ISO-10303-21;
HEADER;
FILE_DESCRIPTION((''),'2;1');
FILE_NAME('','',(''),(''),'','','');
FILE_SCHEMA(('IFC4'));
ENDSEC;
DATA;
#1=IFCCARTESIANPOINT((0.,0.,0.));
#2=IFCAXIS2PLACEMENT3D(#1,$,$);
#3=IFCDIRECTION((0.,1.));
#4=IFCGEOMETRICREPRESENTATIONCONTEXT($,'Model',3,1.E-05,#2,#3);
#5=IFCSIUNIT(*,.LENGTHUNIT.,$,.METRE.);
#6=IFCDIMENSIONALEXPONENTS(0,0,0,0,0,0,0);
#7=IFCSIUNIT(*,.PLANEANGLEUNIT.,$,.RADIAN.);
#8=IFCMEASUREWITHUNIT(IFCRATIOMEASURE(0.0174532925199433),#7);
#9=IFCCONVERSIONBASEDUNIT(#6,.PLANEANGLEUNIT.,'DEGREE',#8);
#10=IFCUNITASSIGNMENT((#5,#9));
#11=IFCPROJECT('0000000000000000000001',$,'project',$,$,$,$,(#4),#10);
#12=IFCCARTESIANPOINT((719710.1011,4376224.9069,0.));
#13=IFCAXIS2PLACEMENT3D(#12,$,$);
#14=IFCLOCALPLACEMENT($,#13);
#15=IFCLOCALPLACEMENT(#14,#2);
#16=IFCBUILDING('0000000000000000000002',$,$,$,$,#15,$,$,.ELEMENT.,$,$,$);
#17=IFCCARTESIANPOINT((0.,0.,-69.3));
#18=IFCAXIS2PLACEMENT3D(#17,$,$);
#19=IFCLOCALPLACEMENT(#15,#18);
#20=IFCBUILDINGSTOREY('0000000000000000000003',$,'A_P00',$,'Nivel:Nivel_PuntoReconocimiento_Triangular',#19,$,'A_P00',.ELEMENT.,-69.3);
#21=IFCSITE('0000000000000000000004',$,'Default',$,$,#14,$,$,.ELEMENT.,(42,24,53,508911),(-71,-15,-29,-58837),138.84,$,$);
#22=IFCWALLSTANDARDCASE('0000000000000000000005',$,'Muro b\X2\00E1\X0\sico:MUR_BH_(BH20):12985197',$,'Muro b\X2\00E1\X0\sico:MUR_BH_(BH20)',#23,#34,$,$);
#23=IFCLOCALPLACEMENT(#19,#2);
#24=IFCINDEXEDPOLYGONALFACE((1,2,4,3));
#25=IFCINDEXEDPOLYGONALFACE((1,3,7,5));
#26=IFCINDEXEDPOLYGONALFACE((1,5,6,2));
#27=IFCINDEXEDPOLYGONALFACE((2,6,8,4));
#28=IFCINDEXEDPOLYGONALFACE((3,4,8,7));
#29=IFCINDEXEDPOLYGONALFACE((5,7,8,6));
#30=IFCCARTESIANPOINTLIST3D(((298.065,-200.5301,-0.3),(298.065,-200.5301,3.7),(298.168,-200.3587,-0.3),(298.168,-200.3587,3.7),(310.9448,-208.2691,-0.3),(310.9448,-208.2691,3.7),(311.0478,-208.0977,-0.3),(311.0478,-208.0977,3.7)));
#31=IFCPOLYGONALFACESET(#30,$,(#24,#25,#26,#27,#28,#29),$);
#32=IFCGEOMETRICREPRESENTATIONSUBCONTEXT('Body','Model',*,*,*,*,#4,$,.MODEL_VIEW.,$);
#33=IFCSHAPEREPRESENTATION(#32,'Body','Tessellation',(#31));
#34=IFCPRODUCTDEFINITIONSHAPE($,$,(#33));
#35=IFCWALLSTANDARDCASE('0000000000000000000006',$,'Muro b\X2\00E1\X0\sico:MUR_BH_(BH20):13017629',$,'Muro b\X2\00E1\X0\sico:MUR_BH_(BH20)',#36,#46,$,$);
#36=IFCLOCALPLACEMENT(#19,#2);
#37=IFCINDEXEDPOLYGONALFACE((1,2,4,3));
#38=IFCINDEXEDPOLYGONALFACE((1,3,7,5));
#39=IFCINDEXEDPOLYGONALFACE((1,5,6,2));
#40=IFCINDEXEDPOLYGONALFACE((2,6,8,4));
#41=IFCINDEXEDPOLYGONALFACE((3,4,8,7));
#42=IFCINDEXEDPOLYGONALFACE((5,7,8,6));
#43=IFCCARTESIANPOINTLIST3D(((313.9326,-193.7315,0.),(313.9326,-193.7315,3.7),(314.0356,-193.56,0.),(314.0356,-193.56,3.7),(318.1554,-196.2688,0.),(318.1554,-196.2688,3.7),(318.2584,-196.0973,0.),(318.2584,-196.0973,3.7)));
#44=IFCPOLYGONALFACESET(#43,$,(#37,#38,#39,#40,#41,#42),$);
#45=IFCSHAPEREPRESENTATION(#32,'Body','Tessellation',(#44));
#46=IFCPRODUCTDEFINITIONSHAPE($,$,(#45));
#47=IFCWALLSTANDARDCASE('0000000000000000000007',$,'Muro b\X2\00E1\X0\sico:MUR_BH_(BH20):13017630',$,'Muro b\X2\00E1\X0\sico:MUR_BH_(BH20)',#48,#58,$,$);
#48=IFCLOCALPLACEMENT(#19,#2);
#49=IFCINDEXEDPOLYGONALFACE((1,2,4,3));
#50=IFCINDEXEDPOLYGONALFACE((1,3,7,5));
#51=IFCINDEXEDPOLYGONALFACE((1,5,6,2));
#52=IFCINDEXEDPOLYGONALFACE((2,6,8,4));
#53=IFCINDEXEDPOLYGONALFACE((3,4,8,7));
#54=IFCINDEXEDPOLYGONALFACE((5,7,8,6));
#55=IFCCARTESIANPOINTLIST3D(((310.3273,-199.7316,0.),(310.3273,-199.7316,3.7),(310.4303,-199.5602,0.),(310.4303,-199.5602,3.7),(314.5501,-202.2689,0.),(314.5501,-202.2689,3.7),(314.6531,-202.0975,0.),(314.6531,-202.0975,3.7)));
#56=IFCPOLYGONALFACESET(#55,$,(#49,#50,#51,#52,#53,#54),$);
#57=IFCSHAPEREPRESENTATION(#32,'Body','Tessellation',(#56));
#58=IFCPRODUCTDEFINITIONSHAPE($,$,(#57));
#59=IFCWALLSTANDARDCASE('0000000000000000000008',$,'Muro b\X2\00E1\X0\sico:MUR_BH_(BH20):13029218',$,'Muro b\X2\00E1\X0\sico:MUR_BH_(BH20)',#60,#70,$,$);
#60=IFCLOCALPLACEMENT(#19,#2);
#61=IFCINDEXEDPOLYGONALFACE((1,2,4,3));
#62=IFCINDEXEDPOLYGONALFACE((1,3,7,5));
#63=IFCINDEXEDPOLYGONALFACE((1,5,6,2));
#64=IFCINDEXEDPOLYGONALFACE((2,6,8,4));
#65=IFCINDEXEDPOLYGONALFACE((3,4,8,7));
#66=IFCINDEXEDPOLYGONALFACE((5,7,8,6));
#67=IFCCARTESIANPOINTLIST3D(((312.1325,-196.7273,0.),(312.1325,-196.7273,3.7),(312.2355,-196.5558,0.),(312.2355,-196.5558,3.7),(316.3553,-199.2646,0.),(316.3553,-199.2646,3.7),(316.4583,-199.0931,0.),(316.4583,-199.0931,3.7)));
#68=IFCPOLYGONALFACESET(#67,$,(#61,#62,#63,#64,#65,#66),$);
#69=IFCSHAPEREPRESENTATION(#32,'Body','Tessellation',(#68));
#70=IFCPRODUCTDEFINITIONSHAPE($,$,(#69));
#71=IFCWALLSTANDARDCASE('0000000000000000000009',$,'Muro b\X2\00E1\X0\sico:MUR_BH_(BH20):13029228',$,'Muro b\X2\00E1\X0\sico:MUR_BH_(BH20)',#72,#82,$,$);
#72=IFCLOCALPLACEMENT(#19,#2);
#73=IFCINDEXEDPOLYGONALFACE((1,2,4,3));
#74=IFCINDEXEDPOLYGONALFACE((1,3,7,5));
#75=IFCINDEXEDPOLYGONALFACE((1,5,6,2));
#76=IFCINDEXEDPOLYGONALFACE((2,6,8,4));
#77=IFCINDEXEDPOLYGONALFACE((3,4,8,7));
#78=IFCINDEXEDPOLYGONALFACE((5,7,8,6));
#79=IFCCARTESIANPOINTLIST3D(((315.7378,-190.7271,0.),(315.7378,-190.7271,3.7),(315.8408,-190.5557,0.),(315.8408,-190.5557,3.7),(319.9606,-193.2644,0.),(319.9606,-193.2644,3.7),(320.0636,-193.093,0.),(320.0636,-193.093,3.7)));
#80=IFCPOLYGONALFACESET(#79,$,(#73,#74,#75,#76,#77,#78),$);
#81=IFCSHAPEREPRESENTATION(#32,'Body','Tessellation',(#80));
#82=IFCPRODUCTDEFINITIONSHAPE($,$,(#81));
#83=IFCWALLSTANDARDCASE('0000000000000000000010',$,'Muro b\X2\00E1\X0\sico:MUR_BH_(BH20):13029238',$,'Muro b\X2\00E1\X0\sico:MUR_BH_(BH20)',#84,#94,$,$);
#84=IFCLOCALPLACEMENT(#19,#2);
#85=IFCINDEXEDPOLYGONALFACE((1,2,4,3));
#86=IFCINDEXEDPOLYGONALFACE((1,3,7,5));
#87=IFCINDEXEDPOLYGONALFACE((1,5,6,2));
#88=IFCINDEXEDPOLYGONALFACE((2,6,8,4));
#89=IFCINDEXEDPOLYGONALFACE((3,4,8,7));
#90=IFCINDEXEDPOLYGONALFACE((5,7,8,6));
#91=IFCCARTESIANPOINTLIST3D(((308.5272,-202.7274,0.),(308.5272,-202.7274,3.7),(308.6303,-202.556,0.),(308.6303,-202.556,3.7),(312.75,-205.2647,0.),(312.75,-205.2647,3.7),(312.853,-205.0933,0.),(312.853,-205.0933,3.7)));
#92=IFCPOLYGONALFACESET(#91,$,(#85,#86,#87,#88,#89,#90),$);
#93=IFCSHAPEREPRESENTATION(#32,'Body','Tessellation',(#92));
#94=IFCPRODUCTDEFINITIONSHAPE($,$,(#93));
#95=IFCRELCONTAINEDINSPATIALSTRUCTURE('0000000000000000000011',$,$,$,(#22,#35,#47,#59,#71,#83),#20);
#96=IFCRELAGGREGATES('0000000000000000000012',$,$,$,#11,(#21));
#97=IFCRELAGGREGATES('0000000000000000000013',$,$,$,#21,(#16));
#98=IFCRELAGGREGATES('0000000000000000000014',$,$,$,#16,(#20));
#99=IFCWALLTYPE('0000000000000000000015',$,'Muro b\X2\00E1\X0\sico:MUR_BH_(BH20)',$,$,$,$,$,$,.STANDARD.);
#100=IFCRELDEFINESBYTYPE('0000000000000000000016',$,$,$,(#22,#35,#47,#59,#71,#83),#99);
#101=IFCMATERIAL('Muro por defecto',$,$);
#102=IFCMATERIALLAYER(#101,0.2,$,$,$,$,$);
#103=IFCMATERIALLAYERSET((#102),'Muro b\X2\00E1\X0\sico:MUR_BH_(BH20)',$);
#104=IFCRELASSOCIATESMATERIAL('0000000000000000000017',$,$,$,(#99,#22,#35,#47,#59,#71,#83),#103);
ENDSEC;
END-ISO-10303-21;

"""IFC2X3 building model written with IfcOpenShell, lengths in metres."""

from ifc_helpers import new_model, entity, si_unit, converted_unit, direction, frame, frame_2d, origin, place, context, subcontext, project, spatial, rectangle, extrude, material, layer, layer_set, layer_usage, type_object, element, save


model = new_model("IFC2X3")

# Units and contexts
model_context = context("Model", 3, precision=1e-05, world=origin(), true_north=direction((0.0, 1.0)))
body_context = subcontext(model_context, "Body", "Model", "MODEL_VIEW")
ifc_project = project(units=[si_unit("LENGTHUNIT", "METRE"), converted_unit("PLANEANGLEUNIT", "DEGREE", entity("IfcRatioMeasure", 0.0174532925199433), si_unit("PLANEANGLEUNIT", "RADIAN"), dimensions=[0, 0, 0, 0, 0, 0, 0])], contexts=[model_context])

# Site, building, storey
site_placement = place(None, frame((719710.1011, 4376224.9069, 0.0)))
site = spatial("IfcSite", under=ifc_project, at=site_placement, Name="Default", CompositionType="ELEMENT", RefLatitude=(42, 24, 53, 508911), RefLongitude=(-71, -15, -29, -58837), RefElevation=138.84)
building_placement = place(site_placement, origin())
building = spatial("IfcBuilding", under=site, at=building_placement, CompositionType="ELEMENT")
storey_placement = place(building_placement, frame((0.0, 0.0, -69.3)))
storey = spatial("IfcBuildingStorey", under=building, at=storey_placement, Name="A_P00", ObjectType="Nivel:Nivel_PuntoReconocimiento_Triangular", LongName="A_P00", CompositionType="ELEMENT", Elevation=-69.3)

# Walls
ifc_material_1 = material(Name="Muro por defecto")
ifc_layer = layer(ifc_material_1, 0.2)
ifc_layer_set = layer_set([ifc_layer], Name="Muro básico:MUR_BH_(BH20)")
ifc_layer_usage_1 = layer_usage(ifc_layer_set, "AXIS2", "NEGATIVE", 0.1)
wall_type = type_object("IfcWallType", Name="Muro básico:MUR_BH_(BH20)", PredefinedType="STANDARD", material=ifc_layer_set)
wall_1_placement = place(storey_placement, frame((310.9963, -208.1834, -0.3), z_axis=(0.0, 0.0, 1.0), x_axis=(-0.857167, 0.515038, 0.0)))
element("IfcWallStandardCase", 1, at=wall_1_placement, inside=storey, type_object=wall_type, material=ifc_layer_usage_1, Name="Muro básico:MUR_BH_(BH20):12985197", ObjectType="Muro básico:MUR_BH_(BH20)", context=body_context, shape_type="SweptSolid", body=[
    extrude(rectangle(XDim=15.026, YDim=0.2, at=frame_2d((7.513, 0.0), x_axis=(-1.0, 0.0))), origin(), (0.0, 0.0, 1.0), 4.0),
])
ifc_layer_usage_2 = layer_usage(ifc_layer_set, "AXIS2", "NEGATIVE", 0.1)
wall_2_placement = place(storey_placement, frame((313.9841, -193.6457, 0.0), z_axis=(0.0, 0.0, 1.0), x_axis=(0.857167, -0.515038, 0.0)))
element("IfcWallStandardCase", 2, at=wall_2_placement, inside=storey, type_object=wall_type, material=ifc_layer_usage_2, Name="Muro básico:MUR_BH_(BH20):13017629", ObjectType="Muro básico:MUR_BH_(BH20)", context=body_context, shape_type="SweptSolid", body=[
    extrude(rectangle(XDim=4.9264, YDim=0.2, at=frame_2d((2.4632, 0.0), x_axis=(-1.0, 0.0))), origin(), (0.0, 0.0, 1.0), 3.7),
])
ifc_layer_usage_3 = layer_usage(ifc_layer_set, "AXIS2", "NEGATIVE", 0.1)
wall_3_placement = place(storey_placement, frame((310.3788, -199.6459, 0.0), z_axis=(0.0, 0.0, 1.0), x_axis=(0.857167, -0.515038, 0.0)))
element("IfcWallStandardCase", 3, at=wall_3_placement, inside=storey, type_object=wall_type, material=ifc_layer_usage_3, Name="Muro básico:MUR_BH_(BH20):13017630", ObjectType="Muro básico:MUR_BH_(BH20)", context=body_context, shape_type="SweptSolid", body=[
    extrude(rectangle(XDim=4.9264, YDim=0.2, at=frame_2d((2.4632, 0.0), x_axis=(-1.0, 0.0))), origin(), (0.0, 0.0, 1.0), 3.7),
])
ifc_layer_usage_4 = layer_usage(ifc_layer_set, "AXIS2", "NEGATIVE", 0.1)
wall_4_placement = place(storey_placement, frame((312.184, -196.6415, 0.0), z_axis=(0.0, 0.0, 1.0), x_axis=(0.857167, -0.515038, 0.0)))
element("IfcWallStandardCase", 4, at=wall_4_placement, inside=storey, type_object=wall_type, material=ifc_layer_usage_4, Name="Muro básico:MUR_BH_(BH20):13029218", ObjectType="Muro básico:MUR_BH_(BH20)", context=body_context, shape_type="SweptSolid", body=[
    extrude(rectangle(XDim=4.9264, YDim=0.2, at=frame_2d((2.4632, 0.0), x_axis=(-1.0, 0.0))), origin(), (0.0, 0.0, 1.0), 3.7),
])
ifc_layer_usage_5 = layer_usage(ifc_layer_set, "AXIS2", "NEGATIVE", 0.1)
wall_5_placement = place(storey_placement, frame((315.7893, -190.6414, 0.0), z_axis=(0.0, 0.0, 1.0), x_axis=(0.857167, -0.515038, 0.0)))
element("IfcWallStandardCase", 5, at=wall_5_placement, inside=storey, type_object=wall_type, material=ifc_layer_usage_5, Name="Muro básico:MUR_BH_(BH20):13029228", ObjectType="Muro básico:MUR_BH_(BH20)", context=body_context, shape_type="SweptSolid", body=[
    extrude(rectangle(XDim=4.9264, YDim=0.2, at=frame_2d((2.4632, 0.0), x_axis=(-1.0, 0.0))), origin(), (0.0, 0.0, 1.0), 3.7),
])
ifc_layer_usage_6 = layer_usage(ifc_layer_set, "AXIS2", "NEGATIVE", 0.1)
wall_6_placement = place(storey_placement, frame((308.5788, -202.6417, 0.0), z_axis=(0.0, 0.0, 1.0), x_axis=(0.857167, -0.515038, 0.0)))
element("IfcWallStandardCase", 6, at=wall_6_placement, inside=storey, type_object=wall_type, material=ifc_layer_usage_6, Name="Muro básico:MUR_BH_(BH20):13029238", ObjectType="Muro básico:MUR_BH_(BH20)", context=body_context, shape_type="SweptSolid", body=[
    extrude(rectangle(XDim=4.9264, YDim=0.2, at=frame_2d((2.4632, 0.0), x_axis=(-1.0, 0.0))), origin(), (0.0, 0.0, 1.0), 3.7),
])

save(model, "model.ifc")
